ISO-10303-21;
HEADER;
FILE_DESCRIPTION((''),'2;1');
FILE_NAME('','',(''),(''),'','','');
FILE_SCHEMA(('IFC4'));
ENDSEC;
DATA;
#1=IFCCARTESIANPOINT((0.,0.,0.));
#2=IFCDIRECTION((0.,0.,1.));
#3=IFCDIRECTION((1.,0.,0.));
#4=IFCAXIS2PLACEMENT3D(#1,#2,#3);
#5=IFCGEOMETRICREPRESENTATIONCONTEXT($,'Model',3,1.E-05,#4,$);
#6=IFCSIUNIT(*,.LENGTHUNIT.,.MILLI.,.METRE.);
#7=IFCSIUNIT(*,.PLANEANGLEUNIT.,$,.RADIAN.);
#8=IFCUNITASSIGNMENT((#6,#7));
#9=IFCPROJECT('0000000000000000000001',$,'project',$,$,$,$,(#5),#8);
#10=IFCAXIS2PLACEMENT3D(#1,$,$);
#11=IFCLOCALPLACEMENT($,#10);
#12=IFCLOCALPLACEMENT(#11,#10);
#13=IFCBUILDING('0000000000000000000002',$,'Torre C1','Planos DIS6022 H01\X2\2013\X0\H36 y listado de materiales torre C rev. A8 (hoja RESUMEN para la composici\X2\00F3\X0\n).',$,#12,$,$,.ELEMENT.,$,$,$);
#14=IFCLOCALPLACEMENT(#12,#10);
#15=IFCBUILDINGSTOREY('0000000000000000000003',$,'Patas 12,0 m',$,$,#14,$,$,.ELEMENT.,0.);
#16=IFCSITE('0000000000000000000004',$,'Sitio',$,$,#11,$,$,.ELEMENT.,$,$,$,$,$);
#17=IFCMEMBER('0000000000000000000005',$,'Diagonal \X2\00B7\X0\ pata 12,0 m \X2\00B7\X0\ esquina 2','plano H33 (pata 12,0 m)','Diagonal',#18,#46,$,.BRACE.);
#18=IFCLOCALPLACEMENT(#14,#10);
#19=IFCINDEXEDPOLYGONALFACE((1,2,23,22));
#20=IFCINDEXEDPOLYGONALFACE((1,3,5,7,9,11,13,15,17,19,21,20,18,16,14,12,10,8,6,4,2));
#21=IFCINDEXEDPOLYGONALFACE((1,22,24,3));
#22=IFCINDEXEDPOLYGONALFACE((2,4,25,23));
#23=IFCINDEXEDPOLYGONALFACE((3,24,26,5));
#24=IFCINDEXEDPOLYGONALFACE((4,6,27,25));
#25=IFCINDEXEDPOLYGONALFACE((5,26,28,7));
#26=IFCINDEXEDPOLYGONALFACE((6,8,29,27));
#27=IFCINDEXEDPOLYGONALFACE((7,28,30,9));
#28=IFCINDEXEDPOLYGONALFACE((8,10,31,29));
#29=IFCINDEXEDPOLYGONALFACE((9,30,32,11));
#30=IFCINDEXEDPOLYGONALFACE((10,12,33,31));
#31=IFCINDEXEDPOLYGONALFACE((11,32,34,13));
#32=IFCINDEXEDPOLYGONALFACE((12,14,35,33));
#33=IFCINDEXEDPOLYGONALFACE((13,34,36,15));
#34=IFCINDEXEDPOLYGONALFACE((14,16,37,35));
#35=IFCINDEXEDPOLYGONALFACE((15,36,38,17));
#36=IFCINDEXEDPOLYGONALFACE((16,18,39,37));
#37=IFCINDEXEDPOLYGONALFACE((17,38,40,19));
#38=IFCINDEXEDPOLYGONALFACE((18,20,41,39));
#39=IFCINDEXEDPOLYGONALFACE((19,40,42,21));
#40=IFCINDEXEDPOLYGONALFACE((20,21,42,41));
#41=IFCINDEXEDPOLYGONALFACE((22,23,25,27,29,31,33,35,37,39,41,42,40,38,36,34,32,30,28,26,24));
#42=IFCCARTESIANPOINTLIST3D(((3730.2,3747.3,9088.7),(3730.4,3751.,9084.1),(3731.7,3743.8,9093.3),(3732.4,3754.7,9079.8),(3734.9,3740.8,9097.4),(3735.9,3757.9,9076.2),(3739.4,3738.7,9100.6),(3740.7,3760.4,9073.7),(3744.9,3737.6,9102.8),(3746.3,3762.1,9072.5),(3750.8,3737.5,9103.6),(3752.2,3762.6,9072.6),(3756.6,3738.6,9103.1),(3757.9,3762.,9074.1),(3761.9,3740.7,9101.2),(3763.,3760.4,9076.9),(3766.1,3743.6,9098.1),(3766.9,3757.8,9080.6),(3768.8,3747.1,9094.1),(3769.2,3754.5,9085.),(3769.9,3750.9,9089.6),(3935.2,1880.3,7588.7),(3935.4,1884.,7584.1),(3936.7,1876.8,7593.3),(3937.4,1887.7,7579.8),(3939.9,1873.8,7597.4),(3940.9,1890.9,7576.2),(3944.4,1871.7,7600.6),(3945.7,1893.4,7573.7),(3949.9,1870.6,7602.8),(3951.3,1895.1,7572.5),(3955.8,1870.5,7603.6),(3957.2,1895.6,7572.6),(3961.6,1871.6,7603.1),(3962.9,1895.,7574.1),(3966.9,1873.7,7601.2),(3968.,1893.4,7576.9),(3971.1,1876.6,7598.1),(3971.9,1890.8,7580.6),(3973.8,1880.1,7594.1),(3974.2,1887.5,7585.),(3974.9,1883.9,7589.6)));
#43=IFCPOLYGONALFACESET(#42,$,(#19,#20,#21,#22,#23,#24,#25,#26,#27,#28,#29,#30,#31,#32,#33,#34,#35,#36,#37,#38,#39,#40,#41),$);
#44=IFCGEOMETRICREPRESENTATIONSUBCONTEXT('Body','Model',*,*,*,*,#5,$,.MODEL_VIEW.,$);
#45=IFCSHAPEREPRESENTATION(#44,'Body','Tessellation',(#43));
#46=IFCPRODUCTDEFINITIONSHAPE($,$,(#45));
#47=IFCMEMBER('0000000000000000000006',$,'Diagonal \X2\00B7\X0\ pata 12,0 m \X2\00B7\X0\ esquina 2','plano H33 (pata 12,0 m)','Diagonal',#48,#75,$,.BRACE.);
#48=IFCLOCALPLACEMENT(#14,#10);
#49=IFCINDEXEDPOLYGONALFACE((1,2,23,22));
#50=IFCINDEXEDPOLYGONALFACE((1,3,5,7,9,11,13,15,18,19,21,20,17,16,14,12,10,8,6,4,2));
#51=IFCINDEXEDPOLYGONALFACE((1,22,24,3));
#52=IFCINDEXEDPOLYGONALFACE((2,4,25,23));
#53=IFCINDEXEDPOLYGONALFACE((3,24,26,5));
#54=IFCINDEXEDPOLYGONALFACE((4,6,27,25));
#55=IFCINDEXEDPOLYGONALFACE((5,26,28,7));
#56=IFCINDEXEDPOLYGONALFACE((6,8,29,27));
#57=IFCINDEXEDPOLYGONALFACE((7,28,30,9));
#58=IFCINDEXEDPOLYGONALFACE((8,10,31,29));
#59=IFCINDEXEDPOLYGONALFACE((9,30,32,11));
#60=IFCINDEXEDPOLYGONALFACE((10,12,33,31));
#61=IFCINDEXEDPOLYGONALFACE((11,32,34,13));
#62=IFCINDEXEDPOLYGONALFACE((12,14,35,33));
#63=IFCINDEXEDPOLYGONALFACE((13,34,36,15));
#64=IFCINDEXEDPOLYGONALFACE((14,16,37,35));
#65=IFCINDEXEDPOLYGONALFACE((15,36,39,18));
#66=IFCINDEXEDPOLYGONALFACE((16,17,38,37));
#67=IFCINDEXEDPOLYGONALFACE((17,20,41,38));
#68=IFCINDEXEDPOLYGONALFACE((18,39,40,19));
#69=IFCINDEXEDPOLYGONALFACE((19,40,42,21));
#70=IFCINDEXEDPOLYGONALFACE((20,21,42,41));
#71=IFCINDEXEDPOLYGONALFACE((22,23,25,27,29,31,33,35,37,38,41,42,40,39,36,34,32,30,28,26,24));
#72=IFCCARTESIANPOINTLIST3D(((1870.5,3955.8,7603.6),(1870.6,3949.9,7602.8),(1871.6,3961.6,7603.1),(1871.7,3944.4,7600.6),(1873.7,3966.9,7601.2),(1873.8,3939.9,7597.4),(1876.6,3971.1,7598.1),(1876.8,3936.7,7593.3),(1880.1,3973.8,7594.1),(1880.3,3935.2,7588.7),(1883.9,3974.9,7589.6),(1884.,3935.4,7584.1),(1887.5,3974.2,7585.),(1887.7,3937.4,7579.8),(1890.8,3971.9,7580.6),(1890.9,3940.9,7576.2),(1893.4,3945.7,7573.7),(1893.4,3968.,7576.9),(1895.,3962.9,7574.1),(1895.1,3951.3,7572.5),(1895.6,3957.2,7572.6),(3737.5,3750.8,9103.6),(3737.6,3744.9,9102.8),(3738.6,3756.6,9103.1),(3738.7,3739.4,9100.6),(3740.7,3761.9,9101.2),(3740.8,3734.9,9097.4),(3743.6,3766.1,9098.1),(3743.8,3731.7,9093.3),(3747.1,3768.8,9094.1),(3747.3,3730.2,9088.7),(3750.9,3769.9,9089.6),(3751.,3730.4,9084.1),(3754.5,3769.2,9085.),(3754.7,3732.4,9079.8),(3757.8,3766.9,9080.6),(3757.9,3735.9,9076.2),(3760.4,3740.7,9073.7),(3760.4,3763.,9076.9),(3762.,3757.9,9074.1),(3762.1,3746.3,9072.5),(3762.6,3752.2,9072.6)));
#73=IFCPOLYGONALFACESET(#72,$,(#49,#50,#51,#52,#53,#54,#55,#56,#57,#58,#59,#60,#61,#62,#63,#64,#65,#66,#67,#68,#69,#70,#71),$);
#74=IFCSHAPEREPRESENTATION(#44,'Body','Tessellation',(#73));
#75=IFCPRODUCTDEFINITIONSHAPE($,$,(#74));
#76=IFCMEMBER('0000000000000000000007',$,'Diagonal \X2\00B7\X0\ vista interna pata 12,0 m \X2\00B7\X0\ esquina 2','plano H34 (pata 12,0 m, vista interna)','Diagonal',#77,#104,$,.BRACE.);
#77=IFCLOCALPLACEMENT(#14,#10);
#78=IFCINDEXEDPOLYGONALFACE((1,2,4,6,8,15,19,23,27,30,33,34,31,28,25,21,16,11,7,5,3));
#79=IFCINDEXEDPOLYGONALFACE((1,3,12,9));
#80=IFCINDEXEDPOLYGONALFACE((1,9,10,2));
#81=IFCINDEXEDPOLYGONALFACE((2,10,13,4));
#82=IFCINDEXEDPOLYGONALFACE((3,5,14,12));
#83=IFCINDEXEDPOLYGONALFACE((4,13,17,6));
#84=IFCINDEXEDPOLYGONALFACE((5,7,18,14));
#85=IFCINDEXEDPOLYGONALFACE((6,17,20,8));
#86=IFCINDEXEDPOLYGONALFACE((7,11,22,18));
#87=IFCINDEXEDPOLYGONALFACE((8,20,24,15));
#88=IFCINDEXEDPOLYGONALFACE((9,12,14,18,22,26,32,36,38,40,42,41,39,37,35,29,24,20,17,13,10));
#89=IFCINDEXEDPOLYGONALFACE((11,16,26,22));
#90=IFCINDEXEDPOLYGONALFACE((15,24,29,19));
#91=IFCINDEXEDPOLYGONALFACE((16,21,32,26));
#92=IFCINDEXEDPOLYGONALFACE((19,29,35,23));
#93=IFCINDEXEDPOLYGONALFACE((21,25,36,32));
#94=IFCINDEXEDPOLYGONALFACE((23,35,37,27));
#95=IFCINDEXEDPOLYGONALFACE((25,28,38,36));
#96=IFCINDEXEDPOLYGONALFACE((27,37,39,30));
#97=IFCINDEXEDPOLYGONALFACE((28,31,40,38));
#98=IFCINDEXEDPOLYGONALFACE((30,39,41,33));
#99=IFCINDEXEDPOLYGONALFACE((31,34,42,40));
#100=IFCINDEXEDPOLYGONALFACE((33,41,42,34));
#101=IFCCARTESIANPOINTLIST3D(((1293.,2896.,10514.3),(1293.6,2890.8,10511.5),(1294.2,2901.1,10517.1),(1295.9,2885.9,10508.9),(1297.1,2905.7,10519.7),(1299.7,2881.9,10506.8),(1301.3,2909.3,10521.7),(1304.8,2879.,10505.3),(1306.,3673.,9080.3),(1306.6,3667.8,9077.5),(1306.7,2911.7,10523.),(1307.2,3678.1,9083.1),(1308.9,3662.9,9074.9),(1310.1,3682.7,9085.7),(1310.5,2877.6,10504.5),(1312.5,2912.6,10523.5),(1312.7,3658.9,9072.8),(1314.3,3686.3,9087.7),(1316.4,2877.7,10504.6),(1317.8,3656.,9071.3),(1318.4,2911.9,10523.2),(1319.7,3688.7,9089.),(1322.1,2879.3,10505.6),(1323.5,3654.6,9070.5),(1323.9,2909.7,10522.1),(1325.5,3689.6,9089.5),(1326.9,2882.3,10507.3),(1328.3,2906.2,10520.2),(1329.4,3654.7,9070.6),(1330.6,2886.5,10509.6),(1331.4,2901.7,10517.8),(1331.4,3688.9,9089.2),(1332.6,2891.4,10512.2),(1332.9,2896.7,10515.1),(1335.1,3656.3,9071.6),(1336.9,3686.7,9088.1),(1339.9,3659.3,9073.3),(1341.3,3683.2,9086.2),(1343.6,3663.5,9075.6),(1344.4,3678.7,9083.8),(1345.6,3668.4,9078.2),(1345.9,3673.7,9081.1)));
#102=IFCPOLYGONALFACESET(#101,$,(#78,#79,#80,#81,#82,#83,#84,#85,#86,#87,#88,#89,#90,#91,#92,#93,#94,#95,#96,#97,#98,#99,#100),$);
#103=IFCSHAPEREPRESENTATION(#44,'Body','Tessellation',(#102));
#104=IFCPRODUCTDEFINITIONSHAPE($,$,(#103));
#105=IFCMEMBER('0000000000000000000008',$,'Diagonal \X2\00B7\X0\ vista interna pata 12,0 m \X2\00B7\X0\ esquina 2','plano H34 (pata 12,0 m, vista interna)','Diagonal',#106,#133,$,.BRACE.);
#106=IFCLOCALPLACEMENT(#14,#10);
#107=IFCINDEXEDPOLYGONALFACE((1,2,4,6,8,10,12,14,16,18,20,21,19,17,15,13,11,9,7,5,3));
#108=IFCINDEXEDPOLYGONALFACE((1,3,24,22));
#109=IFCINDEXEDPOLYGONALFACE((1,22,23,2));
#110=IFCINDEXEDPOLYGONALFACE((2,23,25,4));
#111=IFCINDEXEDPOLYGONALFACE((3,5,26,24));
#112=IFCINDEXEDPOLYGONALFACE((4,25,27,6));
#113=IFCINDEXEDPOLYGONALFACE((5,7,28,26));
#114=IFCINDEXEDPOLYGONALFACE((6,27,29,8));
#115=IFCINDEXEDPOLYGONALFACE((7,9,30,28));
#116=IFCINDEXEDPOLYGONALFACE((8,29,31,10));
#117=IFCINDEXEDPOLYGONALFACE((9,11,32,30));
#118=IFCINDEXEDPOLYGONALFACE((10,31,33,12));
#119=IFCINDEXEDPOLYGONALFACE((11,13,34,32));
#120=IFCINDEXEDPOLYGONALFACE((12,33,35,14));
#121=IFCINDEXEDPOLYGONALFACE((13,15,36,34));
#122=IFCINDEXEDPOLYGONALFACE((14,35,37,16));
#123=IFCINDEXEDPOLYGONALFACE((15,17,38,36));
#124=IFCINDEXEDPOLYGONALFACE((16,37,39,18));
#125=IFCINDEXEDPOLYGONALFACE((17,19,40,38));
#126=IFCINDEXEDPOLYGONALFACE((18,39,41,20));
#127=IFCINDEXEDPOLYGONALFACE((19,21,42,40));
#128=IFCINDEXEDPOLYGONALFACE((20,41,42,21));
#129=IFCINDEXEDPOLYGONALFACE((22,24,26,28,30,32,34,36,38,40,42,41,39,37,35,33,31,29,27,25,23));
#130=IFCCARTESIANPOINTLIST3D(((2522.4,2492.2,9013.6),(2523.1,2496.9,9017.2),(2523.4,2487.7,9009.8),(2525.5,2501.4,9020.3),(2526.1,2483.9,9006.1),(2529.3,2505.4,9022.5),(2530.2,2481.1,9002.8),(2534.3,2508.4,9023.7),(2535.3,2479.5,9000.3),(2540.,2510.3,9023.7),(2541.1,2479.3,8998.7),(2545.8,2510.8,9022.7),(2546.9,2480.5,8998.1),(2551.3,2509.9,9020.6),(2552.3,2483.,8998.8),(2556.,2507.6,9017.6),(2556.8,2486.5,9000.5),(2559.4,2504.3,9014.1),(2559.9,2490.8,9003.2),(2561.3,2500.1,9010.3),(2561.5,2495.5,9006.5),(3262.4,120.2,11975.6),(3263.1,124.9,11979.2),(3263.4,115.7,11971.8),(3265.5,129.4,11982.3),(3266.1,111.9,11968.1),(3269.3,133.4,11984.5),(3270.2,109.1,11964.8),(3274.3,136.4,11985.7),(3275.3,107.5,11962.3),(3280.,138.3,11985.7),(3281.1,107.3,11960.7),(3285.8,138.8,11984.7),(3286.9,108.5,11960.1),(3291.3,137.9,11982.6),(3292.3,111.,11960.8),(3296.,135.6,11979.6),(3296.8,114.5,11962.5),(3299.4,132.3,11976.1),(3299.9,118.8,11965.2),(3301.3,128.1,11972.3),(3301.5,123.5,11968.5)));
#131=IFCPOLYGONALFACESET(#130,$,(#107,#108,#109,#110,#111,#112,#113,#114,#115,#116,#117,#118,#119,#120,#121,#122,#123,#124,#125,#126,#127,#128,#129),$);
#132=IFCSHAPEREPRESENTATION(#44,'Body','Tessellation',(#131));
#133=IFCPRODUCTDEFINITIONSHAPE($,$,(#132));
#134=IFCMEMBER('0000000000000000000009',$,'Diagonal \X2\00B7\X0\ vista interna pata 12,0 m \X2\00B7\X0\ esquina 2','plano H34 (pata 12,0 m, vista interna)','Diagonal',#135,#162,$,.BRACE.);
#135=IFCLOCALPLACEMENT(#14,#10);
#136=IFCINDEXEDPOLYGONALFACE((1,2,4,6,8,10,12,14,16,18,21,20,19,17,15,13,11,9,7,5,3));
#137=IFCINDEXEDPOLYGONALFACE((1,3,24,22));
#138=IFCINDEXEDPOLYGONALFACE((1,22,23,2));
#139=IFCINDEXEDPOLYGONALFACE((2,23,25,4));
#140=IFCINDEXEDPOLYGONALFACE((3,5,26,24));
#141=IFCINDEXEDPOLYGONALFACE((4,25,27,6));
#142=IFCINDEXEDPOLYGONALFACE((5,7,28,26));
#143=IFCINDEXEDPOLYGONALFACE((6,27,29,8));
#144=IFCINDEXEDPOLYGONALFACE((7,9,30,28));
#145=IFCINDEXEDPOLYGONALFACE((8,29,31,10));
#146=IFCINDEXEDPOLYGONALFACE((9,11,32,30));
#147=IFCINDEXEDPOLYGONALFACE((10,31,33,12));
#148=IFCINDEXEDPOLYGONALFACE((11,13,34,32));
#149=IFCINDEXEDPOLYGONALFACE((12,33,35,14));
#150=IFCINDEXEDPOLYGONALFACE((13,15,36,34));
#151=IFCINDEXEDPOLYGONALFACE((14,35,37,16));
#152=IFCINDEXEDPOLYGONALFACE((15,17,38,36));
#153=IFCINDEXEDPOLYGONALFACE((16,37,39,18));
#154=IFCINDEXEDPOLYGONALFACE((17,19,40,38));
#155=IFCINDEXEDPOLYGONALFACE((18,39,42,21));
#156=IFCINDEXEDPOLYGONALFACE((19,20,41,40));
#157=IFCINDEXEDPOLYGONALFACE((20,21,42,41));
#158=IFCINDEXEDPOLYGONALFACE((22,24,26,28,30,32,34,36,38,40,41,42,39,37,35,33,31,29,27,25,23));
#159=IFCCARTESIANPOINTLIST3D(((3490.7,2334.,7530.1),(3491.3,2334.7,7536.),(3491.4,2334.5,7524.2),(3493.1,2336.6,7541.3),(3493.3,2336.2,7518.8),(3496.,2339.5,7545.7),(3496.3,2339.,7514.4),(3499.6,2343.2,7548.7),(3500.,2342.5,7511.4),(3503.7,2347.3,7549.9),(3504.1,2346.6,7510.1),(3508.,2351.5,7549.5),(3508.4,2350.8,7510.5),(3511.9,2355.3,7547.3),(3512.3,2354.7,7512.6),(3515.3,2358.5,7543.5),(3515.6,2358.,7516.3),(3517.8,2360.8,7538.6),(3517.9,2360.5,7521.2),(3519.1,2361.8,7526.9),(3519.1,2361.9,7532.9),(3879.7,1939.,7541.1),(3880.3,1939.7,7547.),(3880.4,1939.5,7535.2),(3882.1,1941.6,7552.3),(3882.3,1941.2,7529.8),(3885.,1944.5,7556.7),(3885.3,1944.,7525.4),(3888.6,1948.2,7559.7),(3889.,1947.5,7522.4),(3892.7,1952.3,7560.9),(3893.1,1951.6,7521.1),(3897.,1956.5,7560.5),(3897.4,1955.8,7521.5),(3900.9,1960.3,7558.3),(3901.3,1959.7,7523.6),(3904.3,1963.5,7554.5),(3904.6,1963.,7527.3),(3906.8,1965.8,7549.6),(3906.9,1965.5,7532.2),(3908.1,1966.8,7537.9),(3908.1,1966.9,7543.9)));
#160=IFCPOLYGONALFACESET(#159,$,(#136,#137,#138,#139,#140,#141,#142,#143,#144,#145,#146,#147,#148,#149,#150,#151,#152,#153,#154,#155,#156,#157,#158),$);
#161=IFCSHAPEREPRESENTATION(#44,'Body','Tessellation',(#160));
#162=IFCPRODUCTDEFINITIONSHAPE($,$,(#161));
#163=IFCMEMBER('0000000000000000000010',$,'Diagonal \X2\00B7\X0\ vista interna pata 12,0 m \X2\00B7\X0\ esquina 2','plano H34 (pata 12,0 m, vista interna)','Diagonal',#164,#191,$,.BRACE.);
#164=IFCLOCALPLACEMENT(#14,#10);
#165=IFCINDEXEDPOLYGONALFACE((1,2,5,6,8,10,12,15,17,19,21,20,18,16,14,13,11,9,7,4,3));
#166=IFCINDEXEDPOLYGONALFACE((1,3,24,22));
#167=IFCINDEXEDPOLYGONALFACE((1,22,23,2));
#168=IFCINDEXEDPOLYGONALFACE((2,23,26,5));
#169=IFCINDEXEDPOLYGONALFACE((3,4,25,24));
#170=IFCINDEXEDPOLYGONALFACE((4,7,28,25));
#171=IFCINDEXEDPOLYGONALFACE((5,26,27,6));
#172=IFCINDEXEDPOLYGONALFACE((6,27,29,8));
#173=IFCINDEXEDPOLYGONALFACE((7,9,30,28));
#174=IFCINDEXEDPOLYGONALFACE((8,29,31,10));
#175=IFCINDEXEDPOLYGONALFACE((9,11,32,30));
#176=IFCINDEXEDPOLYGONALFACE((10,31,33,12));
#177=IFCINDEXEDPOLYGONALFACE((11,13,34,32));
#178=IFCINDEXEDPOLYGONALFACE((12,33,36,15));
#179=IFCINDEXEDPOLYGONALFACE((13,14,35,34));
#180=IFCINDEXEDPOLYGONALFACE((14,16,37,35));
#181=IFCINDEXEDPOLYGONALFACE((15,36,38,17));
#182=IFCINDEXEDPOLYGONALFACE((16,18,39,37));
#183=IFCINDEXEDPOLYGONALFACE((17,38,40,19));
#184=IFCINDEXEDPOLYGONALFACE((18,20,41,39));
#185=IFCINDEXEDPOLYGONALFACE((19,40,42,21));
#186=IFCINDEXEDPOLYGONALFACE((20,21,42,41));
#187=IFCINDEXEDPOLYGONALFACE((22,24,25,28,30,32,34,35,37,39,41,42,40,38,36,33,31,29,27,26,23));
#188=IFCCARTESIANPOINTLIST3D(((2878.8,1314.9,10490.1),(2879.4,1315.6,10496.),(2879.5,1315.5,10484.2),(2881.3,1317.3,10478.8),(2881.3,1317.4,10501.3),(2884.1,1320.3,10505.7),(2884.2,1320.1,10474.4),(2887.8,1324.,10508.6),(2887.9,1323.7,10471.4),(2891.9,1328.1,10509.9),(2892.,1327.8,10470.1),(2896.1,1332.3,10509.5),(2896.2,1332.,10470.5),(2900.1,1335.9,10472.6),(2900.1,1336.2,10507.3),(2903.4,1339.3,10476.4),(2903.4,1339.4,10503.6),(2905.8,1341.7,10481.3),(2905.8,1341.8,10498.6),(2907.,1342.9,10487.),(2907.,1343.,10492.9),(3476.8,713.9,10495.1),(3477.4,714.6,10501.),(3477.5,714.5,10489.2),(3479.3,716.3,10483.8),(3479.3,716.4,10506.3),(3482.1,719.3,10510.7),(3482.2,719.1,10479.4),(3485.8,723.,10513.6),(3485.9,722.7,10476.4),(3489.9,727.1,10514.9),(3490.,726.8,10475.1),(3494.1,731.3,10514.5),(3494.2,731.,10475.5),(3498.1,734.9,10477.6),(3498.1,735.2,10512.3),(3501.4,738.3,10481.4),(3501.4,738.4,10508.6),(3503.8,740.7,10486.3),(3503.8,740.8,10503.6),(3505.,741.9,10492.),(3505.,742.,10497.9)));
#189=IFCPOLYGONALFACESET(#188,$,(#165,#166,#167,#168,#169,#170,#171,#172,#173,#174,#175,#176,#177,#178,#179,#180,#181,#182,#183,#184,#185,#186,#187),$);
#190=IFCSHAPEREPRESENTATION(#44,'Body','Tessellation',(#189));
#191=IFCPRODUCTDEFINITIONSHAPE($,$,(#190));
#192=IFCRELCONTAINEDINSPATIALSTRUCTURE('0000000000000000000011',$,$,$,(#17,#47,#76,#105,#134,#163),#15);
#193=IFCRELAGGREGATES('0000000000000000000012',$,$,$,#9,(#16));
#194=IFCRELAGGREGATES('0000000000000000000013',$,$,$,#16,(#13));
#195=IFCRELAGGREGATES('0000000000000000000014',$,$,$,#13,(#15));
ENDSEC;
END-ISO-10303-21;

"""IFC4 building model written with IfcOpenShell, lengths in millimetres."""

from ifc_helpers import new_model, si_unit, frame, origin, origin_with_axes, place, context, subcontext, project, spatial, circle, extrude, element, save


model = new_model("IFC4")

# Units and contexts
model_context = context("Model", 3, precision=1e-05, world=origin_with_axes())
body_context = subcontext(model_context, "Body", "Model", "MODEL_VIEW")
ifc_project = project(units=[si_unit("LENGTHUNIT", "METRE", prefix="MILLI"), si_unit("PLANEANGLEUNIT", "RADIAN")], contexts=[model_context])

# Site, building, storey
site_placement = place(None, origin())
site = spatial("IfcSite", under=ifc_project, at=site_placement, Name="Sitio", CompositionType="ELEMENT")
building_placement = place(site_placement, origin())
building = spatial("IfcBuilding", under=site, at=building_placement, Name="Torre C1", Description="Planos DIS6022 H01–H36 y listado de materiales torre C rev. A8 (hoja RESUMEN para la composición).", CompositionType="ELEMENT")
storey_placement = place(building_placement, origin())
storey = spatial("IfcBuildingStorey", under=building, at=storey_placement, Name="Patas 12,0 m", CompositionType="ELEMENT", Elevation=0.0)

# Members
for number, where, z_axis, x_axis, name in (
    (1, (3750.0, 3750.0, 9088.0), (0.085286, -0.776723, -0.624041), (-0.912587, -0.312271, 0.263953), "Diagonal · pata 12,0 m · esquina 2"),
    (2, (3750.0, 3750.0, 9088.0), (-0.776723, 0.085286, -0.624041), (-0.312271, -0.912587, 0.263953), "Diagonal · pata 12,0 m · esquina 2"),
):
    element("IfcMember", number, at=place(storey_placement, frame(where, z_axis=z_axis, x_axis=x_axis)), inside=storey, Name=name, Description="plano H33 (pata 12,0 m)", ObjectType="Diagonal", PredefinedType="BRACE", context=body_context, shape_type="SweptSolid", body=[
        extrude(circle(Radius=20.0), None, (0.0, 0.0, 1.0), 2403.7),
    ])
member_1_placement = place(storey_placement, frame((1313.0, 2895.0, 10514.0), z_axis=(0.00797, 0.476387, -0.8792), x_axis=(-0.412414, -0.799402, -0.436888)))
element("IfcMember", 3, at=member_1_placement, inside=storey, Name="Diagonal · vista interna pata 12,0 m · esquina 2", Description="plano H34 (pata 12,0 m, vista interna)", ObjectType="Diagonal", PredefinedType="BRACE", context=body_context, shape_type="SweptSolid", body=[
    extrude(circle(Radius=20.0), None, (0.0, 0.0, 1.0), 1631.0),
])
member_2_placement = place(storey_placement, frame((3282.0, 123.0, 11973.0), z_axis=(-0.191403, 0.613524, -0.766129), x_axis=(-0.929575, -0.363857, -0.059144)))
element("IfcMember", 4, at=member_2_placement, inside=storey, Name="Diagonal · vista interna pata 12,0 m · esquina 2", Description="plano H34 (pata 12,0 m, vista interna)", ObjectType="Diagonal", PredefinedType="BRACE", context=body_context, shape_type="SweptSolid", body=[
    extrude(circle(Radius=20.0), None, (0.0, 0.0, 1.0), 3866.2),
])
member_3_placement = place(storey_placement, frame((3894.0, 1953.0, 7541.0), z_axis=(-0.701537, 0.712357, -0.019838), x_axis=(-0.712559, -0.701594, 0.00509)))
element("IfcMember", 5, at=member_3_placement, inside=storey, Name="Diagonal · vista interna pata 12,0 m · esquina 2", Description="plano H34 (pata 12,0 m, vista interna)", ObjectType="Diagonal", PredefinedType="BRACE", context=body_context, shape_type="SweptSolid", body=[
    extrude(circle(Radius=20.0), None, (0.0, 0.0, 1.0), 554.5),
])
member_4_placement = place(storey_placement, frame((3491.0, 728.0, 10495.0), z_axis=(-0.705323, 0.708861, -0.005897), x_axis=(-0.708883, -0.70532, 0.003004)))
element("IfcMember", 6, at=member_4_placement, inside=storey, Name="Diagonal · vista interna pata 12,0 m · esquina 2", Description="plano H34 (pata 12,0 m, vista interna)", ObjectType="Diagonal", PredefinedType="BRACE", context=body_context, shape_type="SweptSolid", body=[
    extrude(circle(Radius=20.0), None, (0.0, 0.0, 1.0), 847.8),
])

save(model, "model.ifc")
